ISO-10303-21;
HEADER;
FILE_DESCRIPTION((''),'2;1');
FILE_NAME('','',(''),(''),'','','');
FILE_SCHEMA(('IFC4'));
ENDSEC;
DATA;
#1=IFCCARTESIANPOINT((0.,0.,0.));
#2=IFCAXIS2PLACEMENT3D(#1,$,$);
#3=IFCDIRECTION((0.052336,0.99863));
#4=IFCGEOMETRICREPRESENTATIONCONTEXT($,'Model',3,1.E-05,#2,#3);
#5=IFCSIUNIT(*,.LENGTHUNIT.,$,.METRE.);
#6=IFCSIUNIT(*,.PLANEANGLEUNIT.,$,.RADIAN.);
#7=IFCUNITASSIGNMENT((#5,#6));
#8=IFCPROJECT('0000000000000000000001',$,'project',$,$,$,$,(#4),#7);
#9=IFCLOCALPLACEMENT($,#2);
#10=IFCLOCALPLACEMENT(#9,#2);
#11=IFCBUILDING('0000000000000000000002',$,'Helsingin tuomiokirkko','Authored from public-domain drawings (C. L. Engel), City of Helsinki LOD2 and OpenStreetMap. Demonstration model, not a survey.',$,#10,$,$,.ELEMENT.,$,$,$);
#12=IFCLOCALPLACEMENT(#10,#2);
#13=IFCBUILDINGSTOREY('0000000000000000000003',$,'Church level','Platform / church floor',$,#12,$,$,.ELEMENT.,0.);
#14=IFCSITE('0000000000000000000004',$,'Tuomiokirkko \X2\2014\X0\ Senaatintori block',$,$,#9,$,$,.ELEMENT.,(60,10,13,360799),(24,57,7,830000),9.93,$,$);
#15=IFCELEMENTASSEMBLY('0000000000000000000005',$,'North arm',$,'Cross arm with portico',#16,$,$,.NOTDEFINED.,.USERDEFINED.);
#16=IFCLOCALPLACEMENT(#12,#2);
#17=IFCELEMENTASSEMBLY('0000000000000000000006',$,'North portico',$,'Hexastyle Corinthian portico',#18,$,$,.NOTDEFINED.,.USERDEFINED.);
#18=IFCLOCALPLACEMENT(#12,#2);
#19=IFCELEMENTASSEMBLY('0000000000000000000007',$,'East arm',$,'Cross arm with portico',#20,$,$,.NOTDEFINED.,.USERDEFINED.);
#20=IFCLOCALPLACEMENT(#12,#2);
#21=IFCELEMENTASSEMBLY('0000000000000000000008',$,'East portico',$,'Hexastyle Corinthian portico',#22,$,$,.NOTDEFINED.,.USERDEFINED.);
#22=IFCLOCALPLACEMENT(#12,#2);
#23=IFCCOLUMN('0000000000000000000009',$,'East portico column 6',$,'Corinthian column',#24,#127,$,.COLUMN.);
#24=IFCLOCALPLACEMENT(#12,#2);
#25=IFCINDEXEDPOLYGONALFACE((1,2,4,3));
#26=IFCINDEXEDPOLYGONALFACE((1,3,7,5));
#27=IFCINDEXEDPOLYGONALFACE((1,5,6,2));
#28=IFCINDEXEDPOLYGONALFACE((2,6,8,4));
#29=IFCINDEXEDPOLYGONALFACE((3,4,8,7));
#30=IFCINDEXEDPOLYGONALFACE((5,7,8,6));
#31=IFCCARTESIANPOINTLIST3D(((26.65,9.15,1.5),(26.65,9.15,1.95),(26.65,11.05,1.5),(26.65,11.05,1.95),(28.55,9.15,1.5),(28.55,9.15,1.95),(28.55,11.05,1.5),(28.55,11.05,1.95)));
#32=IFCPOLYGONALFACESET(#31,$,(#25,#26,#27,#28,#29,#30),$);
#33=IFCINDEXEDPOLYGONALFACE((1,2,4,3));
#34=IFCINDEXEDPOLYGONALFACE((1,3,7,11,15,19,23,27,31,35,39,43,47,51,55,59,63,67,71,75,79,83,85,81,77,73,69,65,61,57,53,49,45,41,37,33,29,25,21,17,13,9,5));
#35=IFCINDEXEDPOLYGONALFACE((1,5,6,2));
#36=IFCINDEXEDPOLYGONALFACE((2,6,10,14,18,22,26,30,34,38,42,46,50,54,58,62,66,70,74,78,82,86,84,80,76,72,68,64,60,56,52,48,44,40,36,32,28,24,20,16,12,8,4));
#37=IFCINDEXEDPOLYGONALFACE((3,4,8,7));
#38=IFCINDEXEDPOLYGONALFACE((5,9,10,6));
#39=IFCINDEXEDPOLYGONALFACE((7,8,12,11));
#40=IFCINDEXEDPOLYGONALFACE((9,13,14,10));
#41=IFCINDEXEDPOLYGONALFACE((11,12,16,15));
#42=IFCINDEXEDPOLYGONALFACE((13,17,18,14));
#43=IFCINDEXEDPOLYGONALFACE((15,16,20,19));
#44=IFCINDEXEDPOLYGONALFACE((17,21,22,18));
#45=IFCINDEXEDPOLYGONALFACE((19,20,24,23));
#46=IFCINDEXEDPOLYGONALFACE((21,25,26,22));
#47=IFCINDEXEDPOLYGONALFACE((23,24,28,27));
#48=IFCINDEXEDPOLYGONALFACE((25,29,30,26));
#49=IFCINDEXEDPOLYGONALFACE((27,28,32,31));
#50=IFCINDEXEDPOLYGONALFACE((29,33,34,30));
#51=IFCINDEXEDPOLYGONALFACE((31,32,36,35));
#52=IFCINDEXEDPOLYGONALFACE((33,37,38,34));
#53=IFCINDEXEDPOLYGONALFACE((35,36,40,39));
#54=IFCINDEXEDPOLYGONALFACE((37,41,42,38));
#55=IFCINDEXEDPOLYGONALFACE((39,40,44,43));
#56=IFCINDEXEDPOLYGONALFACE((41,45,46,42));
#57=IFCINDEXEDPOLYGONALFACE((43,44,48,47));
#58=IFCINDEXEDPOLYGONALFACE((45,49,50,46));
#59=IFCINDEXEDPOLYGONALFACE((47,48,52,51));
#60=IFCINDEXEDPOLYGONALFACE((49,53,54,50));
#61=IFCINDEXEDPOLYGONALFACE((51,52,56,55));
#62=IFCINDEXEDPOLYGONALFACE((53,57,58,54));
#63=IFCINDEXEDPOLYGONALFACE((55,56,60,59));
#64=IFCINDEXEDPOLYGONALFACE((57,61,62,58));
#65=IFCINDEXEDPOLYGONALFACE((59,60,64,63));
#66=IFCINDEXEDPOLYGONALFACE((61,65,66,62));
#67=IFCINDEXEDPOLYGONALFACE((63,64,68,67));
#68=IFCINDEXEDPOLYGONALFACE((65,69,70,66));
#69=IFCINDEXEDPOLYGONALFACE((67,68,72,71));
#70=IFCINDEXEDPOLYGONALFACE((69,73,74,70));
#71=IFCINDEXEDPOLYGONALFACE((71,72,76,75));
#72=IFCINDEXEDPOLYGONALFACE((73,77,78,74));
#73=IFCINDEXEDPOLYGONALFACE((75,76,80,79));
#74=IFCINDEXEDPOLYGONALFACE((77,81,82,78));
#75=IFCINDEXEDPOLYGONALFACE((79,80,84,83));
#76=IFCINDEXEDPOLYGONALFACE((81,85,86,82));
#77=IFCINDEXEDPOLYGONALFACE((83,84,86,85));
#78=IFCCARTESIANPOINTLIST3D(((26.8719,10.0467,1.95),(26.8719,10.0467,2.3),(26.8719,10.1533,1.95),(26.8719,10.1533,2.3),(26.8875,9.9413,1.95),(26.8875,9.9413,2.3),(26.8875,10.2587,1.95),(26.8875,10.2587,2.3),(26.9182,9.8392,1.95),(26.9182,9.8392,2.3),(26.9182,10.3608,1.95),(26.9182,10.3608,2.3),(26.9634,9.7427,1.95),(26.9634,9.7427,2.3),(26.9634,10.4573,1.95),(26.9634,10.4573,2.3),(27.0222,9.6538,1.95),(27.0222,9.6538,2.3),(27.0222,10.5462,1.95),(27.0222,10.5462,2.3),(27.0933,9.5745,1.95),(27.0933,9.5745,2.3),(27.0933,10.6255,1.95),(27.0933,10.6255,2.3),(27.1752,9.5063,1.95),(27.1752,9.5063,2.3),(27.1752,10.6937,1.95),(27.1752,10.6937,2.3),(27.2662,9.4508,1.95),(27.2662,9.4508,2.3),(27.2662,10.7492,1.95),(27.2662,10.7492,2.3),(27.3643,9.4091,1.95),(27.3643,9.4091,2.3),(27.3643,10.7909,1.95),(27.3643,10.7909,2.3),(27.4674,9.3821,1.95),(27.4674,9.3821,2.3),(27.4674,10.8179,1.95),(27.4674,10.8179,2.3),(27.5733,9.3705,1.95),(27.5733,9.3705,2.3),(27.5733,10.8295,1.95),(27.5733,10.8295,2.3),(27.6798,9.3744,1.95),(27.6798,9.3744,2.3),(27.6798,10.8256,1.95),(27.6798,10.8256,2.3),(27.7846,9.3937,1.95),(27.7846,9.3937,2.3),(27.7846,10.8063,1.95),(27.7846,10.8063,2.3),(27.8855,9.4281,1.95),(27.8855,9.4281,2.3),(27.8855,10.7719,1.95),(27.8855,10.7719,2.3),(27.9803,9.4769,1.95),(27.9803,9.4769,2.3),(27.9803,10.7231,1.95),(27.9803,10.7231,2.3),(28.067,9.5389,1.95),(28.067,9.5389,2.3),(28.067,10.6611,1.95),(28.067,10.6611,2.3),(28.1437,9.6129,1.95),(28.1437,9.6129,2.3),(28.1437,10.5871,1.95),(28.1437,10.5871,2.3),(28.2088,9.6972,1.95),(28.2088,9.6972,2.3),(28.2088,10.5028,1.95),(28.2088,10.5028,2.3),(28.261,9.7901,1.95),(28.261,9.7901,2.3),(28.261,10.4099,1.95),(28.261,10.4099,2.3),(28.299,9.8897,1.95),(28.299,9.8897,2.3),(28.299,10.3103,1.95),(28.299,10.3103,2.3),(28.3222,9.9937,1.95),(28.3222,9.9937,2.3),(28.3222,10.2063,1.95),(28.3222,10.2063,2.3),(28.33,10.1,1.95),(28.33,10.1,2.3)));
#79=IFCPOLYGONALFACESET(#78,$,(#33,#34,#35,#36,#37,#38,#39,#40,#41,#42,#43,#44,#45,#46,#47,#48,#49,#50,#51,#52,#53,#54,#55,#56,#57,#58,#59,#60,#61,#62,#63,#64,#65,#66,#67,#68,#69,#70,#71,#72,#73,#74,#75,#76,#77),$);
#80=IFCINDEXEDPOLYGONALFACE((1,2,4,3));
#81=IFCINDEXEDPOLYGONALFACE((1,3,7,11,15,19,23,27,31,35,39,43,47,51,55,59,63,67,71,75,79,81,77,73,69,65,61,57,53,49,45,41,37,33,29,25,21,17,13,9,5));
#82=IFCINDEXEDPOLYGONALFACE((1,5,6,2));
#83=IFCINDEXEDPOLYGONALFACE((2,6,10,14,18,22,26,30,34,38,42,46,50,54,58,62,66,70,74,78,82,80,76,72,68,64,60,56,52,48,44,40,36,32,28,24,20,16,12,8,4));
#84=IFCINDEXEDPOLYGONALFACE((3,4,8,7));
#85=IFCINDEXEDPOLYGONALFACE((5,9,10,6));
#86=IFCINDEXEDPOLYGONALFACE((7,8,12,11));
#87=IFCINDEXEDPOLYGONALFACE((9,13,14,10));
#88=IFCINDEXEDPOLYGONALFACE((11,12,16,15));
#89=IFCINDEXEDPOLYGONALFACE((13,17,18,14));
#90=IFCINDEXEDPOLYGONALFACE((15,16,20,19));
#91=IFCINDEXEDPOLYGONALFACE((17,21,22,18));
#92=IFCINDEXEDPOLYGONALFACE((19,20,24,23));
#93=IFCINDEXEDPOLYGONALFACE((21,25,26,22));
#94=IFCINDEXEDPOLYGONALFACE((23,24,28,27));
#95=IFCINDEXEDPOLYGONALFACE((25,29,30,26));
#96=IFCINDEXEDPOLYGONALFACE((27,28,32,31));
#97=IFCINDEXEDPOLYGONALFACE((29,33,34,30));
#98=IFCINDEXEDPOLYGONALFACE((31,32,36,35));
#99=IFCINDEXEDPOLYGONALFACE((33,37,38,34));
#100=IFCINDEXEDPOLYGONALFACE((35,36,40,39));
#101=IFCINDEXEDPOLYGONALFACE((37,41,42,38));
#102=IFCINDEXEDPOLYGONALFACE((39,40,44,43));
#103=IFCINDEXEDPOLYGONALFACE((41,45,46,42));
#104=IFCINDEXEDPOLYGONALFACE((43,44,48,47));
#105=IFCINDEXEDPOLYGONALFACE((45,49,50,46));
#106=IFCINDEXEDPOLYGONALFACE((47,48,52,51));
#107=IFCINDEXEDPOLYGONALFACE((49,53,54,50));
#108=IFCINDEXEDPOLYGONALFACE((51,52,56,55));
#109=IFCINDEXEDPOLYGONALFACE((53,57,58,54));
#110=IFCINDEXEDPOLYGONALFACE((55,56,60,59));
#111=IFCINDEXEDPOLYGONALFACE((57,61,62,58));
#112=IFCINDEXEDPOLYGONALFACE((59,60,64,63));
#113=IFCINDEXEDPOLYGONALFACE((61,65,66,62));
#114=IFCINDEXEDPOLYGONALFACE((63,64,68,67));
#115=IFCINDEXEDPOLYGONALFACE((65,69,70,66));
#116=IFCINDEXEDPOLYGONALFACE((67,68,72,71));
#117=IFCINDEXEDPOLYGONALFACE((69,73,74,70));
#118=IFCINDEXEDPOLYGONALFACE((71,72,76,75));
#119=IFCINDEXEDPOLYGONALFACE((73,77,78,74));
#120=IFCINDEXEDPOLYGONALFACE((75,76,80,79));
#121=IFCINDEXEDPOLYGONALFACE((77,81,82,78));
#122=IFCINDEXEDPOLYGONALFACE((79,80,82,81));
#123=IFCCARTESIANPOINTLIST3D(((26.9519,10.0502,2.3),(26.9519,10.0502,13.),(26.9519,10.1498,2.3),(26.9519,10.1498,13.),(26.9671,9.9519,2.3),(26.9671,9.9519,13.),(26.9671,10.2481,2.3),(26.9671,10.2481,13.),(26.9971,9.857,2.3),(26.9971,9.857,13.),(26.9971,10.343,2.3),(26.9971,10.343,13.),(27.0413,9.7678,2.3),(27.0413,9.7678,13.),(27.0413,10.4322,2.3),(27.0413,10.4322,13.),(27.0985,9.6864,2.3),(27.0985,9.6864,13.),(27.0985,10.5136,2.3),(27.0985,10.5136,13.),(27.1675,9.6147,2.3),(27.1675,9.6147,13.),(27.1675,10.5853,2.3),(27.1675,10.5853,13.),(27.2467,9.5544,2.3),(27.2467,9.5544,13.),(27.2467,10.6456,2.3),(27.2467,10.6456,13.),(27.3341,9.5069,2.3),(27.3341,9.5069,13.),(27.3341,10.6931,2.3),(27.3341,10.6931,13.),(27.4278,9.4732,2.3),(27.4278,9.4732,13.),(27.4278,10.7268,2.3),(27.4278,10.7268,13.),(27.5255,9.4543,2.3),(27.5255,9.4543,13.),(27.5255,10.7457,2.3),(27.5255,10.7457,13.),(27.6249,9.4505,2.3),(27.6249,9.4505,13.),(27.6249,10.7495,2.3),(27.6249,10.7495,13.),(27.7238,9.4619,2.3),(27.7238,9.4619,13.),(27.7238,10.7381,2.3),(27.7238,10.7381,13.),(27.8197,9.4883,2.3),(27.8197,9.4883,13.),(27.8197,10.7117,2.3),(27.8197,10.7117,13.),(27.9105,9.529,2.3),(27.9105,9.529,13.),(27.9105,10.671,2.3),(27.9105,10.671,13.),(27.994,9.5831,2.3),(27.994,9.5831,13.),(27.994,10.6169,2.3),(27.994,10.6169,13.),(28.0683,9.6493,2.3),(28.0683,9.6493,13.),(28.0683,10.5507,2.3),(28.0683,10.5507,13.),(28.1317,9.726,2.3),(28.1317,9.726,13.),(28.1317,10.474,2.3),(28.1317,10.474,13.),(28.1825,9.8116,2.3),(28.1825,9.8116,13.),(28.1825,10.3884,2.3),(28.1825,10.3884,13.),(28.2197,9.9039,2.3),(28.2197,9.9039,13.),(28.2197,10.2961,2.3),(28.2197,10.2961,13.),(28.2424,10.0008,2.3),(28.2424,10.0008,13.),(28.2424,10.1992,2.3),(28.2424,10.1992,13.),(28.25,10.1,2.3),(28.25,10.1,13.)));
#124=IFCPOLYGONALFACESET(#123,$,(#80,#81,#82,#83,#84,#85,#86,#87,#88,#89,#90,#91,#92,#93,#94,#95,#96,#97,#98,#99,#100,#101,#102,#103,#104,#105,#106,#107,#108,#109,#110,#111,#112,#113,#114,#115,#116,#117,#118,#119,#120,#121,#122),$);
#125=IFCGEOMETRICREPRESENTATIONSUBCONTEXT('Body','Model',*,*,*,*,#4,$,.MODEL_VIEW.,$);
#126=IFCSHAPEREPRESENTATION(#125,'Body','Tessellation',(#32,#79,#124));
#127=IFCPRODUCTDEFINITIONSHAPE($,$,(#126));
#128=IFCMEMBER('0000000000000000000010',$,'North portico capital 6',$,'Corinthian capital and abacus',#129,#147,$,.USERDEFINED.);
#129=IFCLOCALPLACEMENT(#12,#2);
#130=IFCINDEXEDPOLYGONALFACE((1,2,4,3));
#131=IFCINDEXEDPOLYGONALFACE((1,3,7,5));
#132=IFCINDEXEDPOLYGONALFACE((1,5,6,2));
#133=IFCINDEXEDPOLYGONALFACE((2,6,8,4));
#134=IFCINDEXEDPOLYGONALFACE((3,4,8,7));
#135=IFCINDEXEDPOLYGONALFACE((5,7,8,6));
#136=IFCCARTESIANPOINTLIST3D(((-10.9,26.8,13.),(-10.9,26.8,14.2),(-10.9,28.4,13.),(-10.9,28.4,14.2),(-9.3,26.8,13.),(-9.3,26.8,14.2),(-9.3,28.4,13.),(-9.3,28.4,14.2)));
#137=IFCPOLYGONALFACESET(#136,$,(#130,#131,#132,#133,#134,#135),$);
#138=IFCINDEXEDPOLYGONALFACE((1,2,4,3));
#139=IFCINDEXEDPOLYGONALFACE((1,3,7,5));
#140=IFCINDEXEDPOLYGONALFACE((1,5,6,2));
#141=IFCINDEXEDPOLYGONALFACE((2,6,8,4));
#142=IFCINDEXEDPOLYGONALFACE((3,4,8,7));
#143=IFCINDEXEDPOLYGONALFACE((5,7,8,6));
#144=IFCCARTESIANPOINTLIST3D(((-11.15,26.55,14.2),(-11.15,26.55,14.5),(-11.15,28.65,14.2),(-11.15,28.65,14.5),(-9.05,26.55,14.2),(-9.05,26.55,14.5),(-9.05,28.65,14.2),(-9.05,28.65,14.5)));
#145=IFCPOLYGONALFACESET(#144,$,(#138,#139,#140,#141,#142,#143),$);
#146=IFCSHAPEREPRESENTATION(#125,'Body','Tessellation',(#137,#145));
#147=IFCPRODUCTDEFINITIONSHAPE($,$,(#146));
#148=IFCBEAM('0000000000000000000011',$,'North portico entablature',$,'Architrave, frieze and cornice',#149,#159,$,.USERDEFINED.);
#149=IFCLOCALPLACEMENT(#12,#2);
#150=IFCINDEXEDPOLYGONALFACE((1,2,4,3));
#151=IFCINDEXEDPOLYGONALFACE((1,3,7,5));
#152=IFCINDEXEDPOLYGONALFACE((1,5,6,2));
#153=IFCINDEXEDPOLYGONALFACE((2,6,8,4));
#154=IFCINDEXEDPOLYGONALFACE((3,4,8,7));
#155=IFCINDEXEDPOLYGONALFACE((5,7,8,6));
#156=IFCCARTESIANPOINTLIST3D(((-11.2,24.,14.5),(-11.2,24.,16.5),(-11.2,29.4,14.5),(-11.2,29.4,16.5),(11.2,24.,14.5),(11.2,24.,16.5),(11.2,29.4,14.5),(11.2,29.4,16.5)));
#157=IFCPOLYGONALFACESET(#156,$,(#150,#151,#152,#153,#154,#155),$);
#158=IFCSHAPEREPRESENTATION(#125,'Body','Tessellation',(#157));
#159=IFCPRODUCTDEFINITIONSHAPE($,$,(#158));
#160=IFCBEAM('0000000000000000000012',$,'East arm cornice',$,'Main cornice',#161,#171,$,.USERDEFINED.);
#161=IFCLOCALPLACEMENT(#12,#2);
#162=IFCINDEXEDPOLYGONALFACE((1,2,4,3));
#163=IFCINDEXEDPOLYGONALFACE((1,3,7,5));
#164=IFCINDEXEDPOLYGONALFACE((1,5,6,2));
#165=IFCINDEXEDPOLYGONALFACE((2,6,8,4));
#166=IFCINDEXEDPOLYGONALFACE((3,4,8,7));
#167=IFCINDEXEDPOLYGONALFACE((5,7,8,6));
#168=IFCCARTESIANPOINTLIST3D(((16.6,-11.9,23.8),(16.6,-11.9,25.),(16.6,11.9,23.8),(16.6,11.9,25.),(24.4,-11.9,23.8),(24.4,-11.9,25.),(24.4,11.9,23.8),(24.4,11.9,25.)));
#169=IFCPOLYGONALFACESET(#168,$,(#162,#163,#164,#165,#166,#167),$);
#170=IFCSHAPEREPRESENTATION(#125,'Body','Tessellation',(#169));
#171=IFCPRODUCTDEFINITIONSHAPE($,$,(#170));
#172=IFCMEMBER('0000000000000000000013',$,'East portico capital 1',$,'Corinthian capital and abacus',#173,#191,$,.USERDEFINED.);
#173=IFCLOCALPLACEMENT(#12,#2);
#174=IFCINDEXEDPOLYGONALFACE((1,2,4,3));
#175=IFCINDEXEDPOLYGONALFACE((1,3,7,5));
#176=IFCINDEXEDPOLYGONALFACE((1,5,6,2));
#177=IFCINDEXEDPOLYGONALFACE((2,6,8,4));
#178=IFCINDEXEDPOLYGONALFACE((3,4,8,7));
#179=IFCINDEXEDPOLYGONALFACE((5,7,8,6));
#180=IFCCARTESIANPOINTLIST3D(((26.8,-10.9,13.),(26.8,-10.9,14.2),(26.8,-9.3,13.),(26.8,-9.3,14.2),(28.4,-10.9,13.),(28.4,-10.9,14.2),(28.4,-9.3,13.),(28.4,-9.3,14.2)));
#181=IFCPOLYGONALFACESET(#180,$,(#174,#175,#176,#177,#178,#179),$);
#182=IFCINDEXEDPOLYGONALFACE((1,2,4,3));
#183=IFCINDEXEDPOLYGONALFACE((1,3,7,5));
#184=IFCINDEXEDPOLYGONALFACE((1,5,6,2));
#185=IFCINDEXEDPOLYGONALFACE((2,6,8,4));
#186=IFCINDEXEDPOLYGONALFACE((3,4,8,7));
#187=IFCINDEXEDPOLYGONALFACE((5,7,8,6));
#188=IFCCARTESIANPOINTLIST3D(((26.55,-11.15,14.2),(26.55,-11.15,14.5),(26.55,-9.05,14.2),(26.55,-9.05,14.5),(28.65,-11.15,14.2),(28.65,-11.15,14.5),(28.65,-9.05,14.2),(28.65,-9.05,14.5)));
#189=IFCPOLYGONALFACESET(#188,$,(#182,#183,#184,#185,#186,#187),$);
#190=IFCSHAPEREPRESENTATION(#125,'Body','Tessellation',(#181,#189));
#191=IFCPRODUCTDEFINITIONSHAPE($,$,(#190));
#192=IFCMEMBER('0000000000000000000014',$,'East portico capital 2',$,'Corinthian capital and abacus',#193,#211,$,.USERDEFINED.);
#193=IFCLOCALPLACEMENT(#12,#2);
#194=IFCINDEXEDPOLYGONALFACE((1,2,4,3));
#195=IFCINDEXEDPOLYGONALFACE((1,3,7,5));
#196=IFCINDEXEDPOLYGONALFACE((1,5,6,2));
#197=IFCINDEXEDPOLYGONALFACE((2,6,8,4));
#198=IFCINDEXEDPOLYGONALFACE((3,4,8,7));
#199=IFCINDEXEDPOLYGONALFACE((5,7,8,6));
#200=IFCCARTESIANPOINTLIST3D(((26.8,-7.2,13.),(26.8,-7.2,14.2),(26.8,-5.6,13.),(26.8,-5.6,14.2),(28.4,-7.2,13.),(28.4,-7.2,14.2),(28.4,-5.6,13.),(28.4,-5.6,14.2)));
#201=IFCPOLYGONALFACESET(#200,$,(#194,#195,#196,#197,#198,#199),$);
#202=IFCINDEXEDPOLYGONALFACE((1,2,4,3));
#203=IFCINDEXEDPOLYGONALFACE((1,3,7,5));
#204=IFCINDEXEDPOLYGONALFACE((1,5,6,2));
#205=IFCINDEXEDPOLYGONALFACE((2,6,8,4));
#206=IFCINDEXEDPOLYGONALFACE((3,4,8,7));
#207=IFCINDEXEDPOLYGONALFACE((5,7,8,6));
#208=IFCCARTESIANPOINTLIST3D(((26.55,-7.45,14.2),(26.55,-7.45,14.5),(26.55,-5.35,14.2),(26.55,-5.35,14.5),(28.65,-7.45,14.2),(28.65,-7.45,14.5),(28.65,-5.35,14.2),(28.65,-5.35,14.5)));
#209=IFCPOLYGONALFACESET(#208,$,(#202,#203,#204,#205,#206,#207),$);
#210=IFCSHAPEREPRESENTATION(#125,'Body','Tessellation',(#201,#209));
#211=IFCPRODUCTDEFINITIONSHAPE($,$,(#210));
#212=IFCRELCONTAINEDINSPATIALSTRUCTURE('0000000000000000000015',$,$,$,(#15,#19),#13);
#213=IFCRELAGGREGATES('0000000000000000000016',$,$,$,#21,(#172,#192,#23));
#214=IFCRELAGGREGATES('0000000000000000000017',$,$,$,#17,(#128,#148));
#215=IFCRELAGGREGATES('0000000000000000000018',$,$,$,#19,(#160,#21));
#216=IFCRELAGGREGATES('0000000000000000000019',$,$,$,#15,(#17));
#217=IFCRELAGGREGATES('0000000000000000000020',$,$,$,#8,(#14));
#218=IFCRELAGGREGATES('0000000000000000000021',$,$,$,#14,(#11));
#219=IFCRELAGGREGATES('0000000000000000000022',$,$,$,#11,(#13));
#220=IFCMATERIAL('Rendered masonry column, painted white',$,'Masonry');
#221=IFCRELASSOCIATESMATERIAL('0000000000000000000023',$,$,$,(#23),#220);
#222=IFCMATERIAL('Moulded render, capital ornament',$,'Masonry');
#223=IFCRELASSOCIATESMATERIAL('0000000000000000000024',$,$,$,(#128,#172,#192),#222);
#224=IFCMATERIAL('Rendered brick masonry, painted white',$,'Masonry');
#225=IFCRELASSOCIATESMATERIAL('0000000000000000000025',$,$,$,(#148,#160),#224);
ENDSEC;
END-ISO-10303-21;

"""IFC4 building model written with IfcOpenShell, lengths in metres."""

from ifc_helpers import new_model, si_unit, direction, frame, origin, origin_2d_with_axis, place, context, subcontext, project, spatial, rectangle, circle, extrude, material, element, aggregate, save


model = new_model("IFC4")

# Units and contexts
model_context = context("Model", 3, precision=1e-05, world=origin(), true_north=direction((0.052336, 0.99863)))
body_context = subcontext(model_context, "Body", "Model", "MODEL_VIEW")
ifc_project = project(units=[si_unit("LENGTHUNIT", "METRE"), si_unit("PLANEANGLEUNIT", "RADIAN")], contexts=[model_context])

# Site, building, storey
site_placement = place(None, origin())
site = spatial("IfcSite", under=ifc_project, at=site_placement, Name="Tuomiokirkko — Senaatintori block", CompositionType="ELEMENT", RefLatitude=(60, 10, 13, 360799), RefLongitude=(24, 57, 7, 830000), RefElevation=9.93)
building_placement = place(site_placement, origin())
building = spatial("IfcBuilding", under=site, at=building_placement, Name="Helsingin tuomiokirkko", Description="Authored from public-domain drawings (C. L. Engel), City of Helsinki LOD2 and OpenStreetMap. Demonstration model, not a survey.", CompositionType="ELEMENT")
storey_placement = place(building_placement, origin())
storey = spatial("IfcBuildingStorey", under=building, at=storey_placement, Name="Church level", Description="Platform / church floor", CompositionType="ELEMENT", Elevation=0.0)

# Element assemblies
assembly_1_placement = place(building_placement, origin())
assembly_1 = element("IfcElementAssembly", 1, at=assembly_1_placement, inside=storey, Name="North arm", ObjectType="Cross arm with portico", AssemblyPlace="NOTDEFINED", PredefinedType="USERDEFINED")
assembly_2_placement = place(building_placement, origin())
assembly_2 = element("IfcElementAssembly", 2, at=assembly_2_placement, Name="North portico", ObjectType="Hexastyle Corinthian portico", AssemblyPlace="NOTDEFINED", PredefinedType="USERDEFINED")
ifc_material_1 = material(Name="Rendered masonry column, painted white", Category="Masonry")

# Element assemblies, column
assembly_3_placement = place(building_placement, origin())
assembly_3 = element("IfcElementAssembly", 3, at=assembly_3_placement, inside=storey, Name="East arm", ObjectType="Cross arm with portico", AssemblyPlace="NOTDEFINED", PredefinedType="USERDEFINED")
ifc_material_2 = material(Name="Rendered brick masonry, painted white", Category="Masonry")
assembly_4_placement = place(building_placement, origin())
assembly_4 = element("IfcElementAssembly", 4, at=assembly_4_placement, Name="East portico", ObjectType="Hexastyle Corinthian portico", AssemblyPlace="NOTDEFINED", PredefinedType="USERDEFINED")
column_1_placement = place(building_placement, origin())
column_1 = element("IfcColumn", 5, at=column_1_placement, material=ifc_material_1, Name="East portico column 6", ObjectType="Corinthian column", PredefinedType="COLUMN", context=body_context, shape_type="SweptSolid", body=[
    extrude(rectangle(XDim=1.9, YDim=1.9, at=origin_2d_with_axis()), frame((27.6, 10.1, 1.5)), (0.0, 0.0, 1.0), 0.45),
    extrude(circle(Radius=0.73, at=origin_2d_with_axis()), frame((27.6, 10.1, 1.95)), (0.0, 0.0, 1.0), 0.35),
    extrude(circle(Radius=0.65, at=origin_2d_with_axis()), frame((27.6, 10.1, 2.3)), (0.0, 0.0, 1.0), 10.7),
])

# Member
ifc_material_3 = material(Name="Moulded render, capital ornament", Category="Masonry")
member_1_placement = place(building_placement, origin())
member_1 = element("IfcMember", 6, at=member_1_placement, material=ifc_material_3, Name="North portico capital 6", ObjectType="Corinthian capital and abacus", PredefinedType="USERDEFINED", context=body_context, shape_type="SweptSolid", body=[
    extrude(rectangle(XDim=1.6, YDim=1.6, at=origin_2d_with_axis()), frame((-10.1, 27.6, 13.0)), (0.0, 0.0, 1.0), 1.2),
    extrude(rectangle(XDim=2.1, YDim=2.1, at=origin_2d_with_axis()), frame((-10.1, 27.6, 14.2)), (0.0, 0.0, 1.0), 0.3),
])

# Beams
beam_1_placement = place(building_placement, origin())
beam_1 = element("IfcBeam", 7, at=beam_1_placement, material=ifc_material_2, Name="North portico entablature", ObjectType="Architrave, frieze and cornice", PredefinedType="USERDEFINED", context=body_context, shape_type="SweptSolid", body=[
    extrude(rectangle(XDim=22.4, YDim=5.4, at=origin_2d_with_axis()), frame((0.0, 26.7, 14.5)), (0.0, 0.0, 1.0), 2.0),
])
beam_2_placement = place(building_placement, origin())
beam_2 = element("IfcBeam", 8, at=beam_2_placement, material=ifc_material_2, Name="East arm cornice", ObjectType="Main cornice", PredefinedType="USERDEFINED", context=body_context, shape_type="SweptSolid", body=[
    extrude(rectangle(XDim=7.8, YDim=23.8, at=origin_2d_with_axis()), frame((20.5, 0.0, 23.8)), (0.0, 0.0, 1.0), 1.2),
])

# Members
member_2_placement = place(building_placement, origin())
member_2 = element("IfcMember", 9, at=member_2_placement, material=ifc_material_3, Name="East portico capital 1", ObjectType="Corinthian capital and abacus", PredefinedType="USERDEFINED", context=body_context, shape_type="SweptSolid", body=[
    extrude(rectangle(XDim=1.6, YDim=1.6, at=origin_2d_with_axis()), frame((27.6, -10.1, 13.0)), (0.0, 0.0, 1.0), 1.2),
    extrude(rectangle(XDim=2.1, YDim=2.1, at=origin_2d_with_axis()), frame((27.6, -10.1, 14.2)), (0.0, 0.0, 1.0), 0.3),
])
member_3_placement = place(building_placement, origin())
member_3 = element("IfcMember", 10, at=member_3_placement, material=ifc_material_3, Name="East portico capital 2", ObjectType="Corinthian capital and abacus", PredefinedType="USERDEFINED", context=body_context, shape_type="SweptSolid", body=[
    extrude(rectangle(XDim=1.6, YDim=1.6, at=origin_2d_with_axis()), frame((27.6, -6.4, 13.0)), (0.0, 0.0, 1.0), 1.2),
    extrude(rectangle(XDim=2.1, YDim=2.1, at=origin_2d_with_axis()), frame((27.6, -6.4, 14.2)), (0.0, 0.0, 1.0), 0.3),
])

aggregate(assembly_4, [member_2, member_3, column_1])

aggregate(assembly_2, [member_1, beam_1])
aggregate(assembly_3, [beam_2, assembly_4])

aggregate(assembly_1, [assembly_2])

save(model, "model.ifc")
